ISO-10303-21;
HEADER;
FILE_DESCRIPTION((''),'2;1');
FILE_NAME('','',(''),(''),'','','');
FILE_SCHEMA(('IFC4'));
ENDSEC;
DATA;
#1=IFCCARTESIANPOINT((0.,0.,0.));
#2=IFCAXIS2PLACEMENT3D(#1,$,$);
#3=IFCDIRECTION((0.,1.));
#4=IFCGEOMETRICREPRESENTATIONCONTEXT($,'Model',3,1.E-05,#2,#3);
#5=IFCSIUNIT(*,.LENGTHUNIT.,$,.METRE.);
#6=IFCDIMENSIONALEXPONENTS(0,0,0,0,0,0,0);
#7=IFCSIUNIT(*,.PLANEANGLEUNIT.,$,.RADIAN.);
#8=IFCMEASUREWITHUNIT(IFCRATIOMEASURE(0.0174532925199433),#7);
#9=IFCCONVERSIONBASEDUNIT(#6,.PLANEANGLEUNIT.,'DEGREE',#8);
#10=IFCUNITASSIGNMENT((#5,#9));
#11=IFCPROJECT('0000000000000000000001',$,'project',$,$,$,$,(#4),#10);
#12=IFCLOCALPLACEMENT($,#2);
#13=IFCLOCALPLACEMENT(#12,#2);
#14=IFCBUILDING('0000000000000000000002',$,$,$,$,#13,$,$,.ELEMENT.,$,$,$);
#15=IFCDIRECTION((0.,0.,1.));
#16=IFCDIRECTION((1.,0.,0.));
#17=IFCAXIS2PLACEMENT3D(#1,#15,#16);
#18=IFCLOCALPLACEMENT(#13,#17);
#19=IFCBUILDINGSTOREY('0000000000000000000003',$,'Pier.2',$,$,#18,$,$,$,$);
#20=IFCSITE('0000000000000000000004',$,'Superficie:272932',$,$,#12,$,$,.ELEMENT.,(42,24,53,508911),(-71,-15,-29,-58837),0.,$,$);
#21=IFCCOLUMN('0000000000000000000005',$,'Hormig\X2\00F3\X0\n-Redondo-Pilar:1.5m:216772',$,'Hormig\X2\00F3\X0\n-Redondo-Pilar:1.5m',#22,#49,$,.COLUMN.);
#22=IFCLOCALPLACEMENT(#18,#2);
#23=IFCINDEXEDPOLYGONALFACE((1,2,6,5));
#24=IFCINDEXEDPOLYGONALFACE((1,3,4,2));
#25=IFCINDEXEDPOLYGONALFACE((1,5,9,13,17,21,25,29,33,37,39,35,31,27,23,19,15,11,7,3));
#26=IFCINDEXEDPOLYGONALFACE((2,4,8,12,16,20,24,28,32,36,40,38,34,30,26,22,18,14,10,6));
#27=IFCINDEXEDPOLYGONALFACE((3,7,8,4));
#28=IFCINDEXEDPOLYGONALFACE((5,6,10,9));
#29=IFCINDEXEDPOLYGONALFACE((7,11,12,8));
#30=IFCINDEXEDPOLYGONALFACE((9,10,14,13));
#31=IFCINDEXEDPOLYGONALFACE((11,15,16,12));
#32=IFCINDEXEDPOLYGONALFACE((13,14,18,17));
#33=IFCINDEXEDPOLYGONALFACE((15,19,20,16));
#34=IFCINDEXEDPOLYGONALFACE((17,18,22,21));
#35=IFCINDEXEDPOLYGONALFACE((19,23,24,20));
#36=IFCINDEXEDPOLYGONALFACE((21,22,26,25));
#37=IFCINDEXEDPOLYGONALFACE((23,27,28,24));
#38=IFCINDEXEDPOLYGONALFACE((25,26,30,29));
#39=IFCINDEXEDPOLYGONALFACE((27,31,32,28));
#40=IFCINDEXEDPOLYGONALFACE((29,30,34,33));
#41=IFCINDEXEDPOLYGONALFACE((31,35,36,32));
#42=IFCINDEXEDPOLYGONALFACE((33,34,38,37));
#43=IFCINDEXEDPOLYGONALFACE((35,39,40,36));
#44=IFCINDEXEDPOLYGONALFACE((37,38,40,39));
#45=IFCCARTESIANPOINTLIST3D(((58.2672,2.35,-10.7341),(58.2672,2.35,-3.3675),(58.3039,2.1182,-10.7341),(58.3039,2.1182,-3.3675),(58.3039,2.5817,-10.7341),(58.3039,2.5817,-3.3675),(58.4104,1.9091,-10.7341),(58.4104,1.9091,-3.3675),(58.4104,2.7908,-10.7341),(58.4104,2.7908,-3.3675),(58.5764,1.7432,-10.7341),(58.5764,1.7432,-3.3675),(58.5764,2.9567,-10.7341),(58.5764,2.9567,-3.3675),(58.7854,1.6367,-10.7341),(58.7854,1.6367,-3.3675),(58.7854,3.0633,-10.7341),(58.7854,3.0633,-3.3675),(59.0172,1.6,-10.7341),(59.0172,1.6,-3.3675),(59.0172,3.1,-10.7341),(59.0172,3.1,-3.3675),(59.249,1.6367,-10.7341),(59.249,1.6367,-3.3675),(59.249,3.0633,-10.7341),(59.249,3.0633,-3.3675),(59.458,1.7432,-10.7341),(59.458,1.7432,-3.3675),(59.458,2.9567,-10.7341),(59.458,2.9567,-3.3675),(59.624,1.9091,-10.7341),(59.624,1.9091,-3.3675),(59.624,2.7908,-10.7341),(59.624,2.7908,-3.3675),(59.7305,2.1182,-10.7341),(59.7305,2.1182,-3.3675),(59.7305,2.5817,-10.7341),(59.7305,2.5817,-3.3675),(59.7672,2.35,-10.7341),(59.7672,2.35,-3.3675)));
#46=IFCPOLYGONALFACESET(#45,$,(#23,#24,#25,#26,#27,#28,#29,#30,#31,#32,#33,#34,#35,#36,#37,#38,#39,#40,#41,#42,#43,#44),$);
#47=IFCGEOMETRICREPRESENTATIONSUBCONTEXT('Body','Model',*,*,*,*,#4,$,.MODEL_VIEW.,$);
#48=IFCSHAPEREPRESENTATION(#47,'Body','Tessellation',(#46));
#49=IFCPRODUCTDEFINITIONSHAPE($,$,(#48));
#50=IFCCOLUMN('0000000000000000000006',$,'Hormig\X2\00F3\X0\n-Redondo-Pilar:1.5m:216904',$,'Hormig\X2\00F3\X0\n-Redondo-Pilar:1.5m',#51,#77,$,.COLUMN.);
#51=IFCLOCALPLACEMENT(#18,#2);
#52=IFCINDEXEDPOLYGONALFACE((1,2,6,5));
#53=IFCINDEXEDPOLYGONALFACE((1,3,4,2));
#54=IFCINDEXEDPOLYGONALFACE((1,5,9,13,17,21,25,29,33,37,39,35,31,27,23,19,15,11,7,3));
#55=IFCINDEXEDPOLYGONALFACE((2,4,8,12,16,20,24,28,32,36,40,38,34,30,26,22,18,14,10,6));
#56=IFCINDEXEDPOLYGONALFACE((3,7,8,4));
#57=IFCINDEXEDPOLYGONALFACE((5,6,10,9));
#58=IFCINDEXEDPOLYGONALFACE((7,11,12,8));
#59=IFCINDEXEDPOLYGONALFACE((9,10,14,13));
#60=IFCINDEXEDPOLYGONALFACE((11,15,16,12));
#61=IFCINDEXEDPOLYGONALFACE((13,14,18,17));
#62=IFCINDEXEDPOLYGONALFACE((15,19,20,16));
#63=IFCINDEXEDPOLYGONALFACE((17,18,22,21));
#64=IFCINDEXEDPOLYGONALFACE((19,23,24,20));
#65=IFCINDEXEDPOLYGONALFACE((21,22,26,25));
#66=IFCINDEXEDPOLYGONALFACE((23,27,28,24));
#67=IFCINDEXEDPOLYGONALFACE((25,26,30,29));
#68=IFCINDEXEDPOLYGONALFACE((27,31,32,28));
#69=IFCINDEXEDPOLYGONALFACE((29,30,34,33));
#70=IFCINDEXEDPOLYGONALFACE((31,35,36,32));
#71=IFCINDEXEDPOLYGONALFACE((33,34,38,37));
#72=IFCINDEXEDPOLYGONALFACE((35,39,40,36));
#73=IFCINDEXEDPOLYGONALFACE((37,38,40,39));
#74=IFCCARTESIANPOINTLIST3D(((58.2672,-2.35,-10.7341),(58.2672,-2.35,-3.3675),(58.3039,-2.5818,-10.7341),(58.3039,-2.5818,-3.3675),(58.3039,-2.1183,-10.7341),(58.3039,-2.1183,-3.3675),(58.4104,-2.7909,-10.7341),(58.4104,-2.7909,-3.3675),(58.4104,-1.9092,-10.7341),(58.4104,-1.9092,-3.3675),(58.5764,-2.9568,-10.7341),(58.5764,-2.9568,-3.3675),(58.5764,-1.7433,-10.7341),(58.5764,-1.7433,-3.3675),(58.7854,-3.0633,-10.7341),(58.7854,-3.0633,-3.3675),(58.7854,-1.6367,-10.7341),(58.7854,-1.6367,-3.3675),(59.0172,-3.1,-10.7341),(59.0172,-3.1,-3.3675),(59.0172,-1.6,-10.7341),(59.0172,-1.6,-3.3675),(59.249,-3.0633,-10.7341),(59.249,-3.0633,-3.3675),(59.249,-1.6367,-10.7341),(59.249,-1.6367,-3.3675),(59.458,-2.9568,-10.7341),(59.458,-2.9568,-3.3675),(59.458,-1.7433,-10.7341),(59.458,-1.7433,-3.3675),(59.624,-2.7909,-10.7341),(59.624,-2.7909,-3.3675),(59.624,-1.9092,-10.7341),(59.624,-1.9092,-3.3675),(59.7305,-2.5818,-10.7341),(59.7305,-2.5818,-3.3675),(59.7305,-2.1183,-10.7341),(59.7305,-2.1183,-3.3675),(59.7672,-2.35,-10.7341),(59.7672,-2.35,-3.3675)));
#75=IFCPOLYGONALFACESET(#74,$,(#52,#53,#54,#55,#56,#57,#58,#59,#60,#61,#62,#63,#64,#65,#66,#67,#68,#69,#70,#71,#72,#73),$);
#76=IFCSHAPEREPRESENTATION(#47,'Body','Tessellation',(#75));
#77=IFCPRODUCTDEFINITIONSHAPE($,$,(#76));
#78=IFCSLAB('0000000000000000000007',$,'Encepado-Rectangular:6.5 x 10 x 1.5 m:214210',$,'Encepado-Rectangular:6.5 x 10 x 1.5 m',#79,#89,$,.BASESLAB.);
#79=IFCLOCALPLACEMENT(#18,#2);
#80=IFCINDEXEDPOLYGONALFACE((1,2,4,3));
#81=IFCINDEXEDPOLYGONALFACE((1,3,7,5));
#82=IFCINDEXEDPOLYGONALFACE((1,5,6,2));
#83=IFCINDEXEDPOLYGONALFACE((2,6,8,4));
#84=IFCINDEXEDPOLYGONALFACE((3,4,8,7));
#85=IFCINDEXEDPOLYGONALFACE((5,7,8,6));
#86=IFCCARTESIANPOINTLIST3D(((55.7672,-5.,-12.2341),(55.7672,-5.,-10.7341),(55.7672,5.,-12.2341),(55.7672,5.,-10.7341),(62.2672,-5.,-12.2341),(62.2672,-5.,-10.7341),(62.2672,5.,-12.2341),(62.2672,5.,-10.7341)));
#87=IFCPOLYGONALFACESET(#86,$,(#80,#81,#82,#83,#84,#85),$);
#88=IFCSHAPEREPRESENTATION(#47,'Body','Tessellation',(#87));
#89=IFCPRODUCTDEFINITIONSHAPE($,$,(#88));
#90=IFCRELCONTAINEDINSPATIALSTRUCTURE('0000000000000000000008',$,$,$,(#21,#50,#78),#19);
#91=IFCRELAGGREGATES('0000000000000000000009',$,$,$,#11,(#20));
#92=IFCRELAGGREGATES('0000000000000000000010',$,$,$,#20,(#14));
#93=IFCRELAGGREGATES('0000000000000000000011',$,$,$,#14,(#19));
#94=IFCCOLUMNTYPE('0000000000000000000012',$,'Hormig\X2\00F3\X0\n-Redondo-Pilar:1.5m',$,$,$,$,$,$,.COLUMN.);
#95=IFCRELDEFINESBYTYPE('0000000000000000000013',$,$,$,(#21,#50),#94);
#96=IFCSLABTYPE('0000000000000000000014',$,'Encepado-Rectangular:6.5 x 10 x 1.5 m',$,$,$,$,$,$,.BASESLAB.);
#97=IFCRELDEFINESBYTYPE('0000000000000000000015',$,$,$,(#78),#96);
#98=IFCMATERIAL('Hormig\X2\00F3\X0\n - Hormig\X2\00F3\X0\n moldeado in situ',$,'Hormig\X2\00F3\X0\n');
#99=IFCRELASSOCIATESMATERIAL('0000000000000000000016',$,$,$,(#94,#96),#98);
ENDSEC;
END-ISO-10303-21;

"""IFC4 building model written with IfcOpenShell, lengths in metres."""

from ifc_helpers import new_model, entity, si_unit, converted_unit, direction, frame, origin, origin_with_axes, place, context, subcontext, project, spatial, indexed_curve, outline, extrude, source, transform, mapped, material, type_object, type_shapes, element, save


model = new_model("IFC4")

# Units and contexts
model_context = context("Model", 3, precision=1e-05, world=origin(), true_north=direction((0.0, 1.0)))
body_context = subcontext(model_context, "Body", "Model", "MODEL_VIEW")
ifc_project = project(units=[si_unit("LENGTHUNIT", "METRE"), converted_unit("PLANEANGLEUNIT", "DEGREE", entity("IfcRatioMeasure", 0.0174532925199433), si_unit("PLANEANGLEUNIT", "RADIAN"), dimensions=[0, 0, 0, 0, 0, 0, 0])], contexts=[model_context])

# Site, building, storey
site_placement = place(None, origin())
site = spatial("IfcSite", under=ifc_project, at=site_placement, Name="Superficie:272932", CompositionType="ELEMENT", RefLatitude=(42, 24, 53, 508911), RefLongitude=(-71, -15, -29, -58837), RefElevation=0.0)
building_placement = place(site_placement, origin())
building = spatial("IfcBuilding", under=site, at=building_placement, CompositionType="ELEMENT")
storey_placement = place(building_placement, origin_with_axes())
storey = spatial("IfcBuildingStorey", under=building, at=storey_placement, Name="Pier.2")

# Columns
ifc_material = material(Name="Hormigón - Hormigón moldeado in situ", Category="Hormigón")
column_type = type_object("IfcColumnType", Name="Hormigón-Redondo-Pilar:1.5m", PredefinedType="COLUMN", material=ifc_material)
shared_shape = source(origin(), body_context, "Body", "SweptSolid", [
    extrude(outline(indexed_curve([(0.75, 0.0), (0.7133, 0.2318), (0.6068, 0.4408), (0.4408, 0.6068), (0.2318, 0.7133), (0.0, 0.75), (-0.2318, 0.7133), (-0.4408, 0.6068), (-0.6068, 0.4408), (-0.7133, 0.2318), (-0.75, 0.0), (-0.7133, -0.2318), (-0.6068, -0.4408), (-0.4408, -0.6068), (-0.2318, -0.7133), (0.0, -0.75), (0.2318, -0.7133), (0.4408, -0.6068), (0.6068, -0.4408), (0.7133, -0.2318), (0.75, 0.0)], self_intersect=False)), frame((0.0, 0.0, -10.7341)), (0.0, 0.0, 1.0), 7.3666),
])
type_shapes(column_type, [shared_shape])
for number, where, z_axis, x_axis, name in (
    (1, (59.0172, 2.35, 0.0), (0.0, 0.0, 1.0), (1.0, 0.0, 0.0), "Hormigón-Redondo-Pilar:1.5m:216772"),
    (2, (59.0172, -2.35, 0.0), (0.0, 0.0, 1.0), (1.0, 0.0, 0.0), "Hormigón-Redondo-Pilar:1.5m:216904"),
):
    element("IfcColumn", number, at=place(storey_placement, frame(where, z_axis=z_axis, x_axis=x_axis)), inside=storey, type_object=column_type, Name=name, ObjectType="Hormigón-Redondo-Pilar:1.5m", PredefinedType="COLUMN", context=body_context, shape_type="MappedRepresentation", body=[
        mapped(shared_shape, transform((0.0, 0.0, 0.0), scale=1.0)),
    ])

# Slab
slab_type = type_object("IfcSlabType", Name="Encepado-Rectangular:6.5 x 10 x 1.5 m", PredefinedType="BASESLAB", material=ifc_material)
slab_placement = place(storey_placement, frame((0.0, 0.0, -10.7341), z_axis=(0.0, 0.0, 1.0), x_axis=(1.0, 0.0, 0.0)))
element("IfcSlab", 3, at=slab_placement, inside=storey, type_object=slab_type, Name="Encepado-Rectangular:6.5 x 10 x 1.5 m:214210", ObjectType="Encepado-Rectangular:6.5 x 10 x 1.5 m", PredefinedType="BASESLAB", context=body_context, shape_type="SweptSolid", body=[
    extrude(outline(indexed_curve([(-3.25, -5.0), (3.25, -5.0), (3.25, 5.0), (-3.25, 5.0), (-3.25, -5.0)], self_intersect=False)), frame((59.0172, 0.0, -1.5), z_axis=(0.0, 0.0, 1.0), x_axis=(-1.0, 0.0, 0.0)), (0.0, 0.0, 1.0), 1.5),
])

save(model, "model.ifc")
